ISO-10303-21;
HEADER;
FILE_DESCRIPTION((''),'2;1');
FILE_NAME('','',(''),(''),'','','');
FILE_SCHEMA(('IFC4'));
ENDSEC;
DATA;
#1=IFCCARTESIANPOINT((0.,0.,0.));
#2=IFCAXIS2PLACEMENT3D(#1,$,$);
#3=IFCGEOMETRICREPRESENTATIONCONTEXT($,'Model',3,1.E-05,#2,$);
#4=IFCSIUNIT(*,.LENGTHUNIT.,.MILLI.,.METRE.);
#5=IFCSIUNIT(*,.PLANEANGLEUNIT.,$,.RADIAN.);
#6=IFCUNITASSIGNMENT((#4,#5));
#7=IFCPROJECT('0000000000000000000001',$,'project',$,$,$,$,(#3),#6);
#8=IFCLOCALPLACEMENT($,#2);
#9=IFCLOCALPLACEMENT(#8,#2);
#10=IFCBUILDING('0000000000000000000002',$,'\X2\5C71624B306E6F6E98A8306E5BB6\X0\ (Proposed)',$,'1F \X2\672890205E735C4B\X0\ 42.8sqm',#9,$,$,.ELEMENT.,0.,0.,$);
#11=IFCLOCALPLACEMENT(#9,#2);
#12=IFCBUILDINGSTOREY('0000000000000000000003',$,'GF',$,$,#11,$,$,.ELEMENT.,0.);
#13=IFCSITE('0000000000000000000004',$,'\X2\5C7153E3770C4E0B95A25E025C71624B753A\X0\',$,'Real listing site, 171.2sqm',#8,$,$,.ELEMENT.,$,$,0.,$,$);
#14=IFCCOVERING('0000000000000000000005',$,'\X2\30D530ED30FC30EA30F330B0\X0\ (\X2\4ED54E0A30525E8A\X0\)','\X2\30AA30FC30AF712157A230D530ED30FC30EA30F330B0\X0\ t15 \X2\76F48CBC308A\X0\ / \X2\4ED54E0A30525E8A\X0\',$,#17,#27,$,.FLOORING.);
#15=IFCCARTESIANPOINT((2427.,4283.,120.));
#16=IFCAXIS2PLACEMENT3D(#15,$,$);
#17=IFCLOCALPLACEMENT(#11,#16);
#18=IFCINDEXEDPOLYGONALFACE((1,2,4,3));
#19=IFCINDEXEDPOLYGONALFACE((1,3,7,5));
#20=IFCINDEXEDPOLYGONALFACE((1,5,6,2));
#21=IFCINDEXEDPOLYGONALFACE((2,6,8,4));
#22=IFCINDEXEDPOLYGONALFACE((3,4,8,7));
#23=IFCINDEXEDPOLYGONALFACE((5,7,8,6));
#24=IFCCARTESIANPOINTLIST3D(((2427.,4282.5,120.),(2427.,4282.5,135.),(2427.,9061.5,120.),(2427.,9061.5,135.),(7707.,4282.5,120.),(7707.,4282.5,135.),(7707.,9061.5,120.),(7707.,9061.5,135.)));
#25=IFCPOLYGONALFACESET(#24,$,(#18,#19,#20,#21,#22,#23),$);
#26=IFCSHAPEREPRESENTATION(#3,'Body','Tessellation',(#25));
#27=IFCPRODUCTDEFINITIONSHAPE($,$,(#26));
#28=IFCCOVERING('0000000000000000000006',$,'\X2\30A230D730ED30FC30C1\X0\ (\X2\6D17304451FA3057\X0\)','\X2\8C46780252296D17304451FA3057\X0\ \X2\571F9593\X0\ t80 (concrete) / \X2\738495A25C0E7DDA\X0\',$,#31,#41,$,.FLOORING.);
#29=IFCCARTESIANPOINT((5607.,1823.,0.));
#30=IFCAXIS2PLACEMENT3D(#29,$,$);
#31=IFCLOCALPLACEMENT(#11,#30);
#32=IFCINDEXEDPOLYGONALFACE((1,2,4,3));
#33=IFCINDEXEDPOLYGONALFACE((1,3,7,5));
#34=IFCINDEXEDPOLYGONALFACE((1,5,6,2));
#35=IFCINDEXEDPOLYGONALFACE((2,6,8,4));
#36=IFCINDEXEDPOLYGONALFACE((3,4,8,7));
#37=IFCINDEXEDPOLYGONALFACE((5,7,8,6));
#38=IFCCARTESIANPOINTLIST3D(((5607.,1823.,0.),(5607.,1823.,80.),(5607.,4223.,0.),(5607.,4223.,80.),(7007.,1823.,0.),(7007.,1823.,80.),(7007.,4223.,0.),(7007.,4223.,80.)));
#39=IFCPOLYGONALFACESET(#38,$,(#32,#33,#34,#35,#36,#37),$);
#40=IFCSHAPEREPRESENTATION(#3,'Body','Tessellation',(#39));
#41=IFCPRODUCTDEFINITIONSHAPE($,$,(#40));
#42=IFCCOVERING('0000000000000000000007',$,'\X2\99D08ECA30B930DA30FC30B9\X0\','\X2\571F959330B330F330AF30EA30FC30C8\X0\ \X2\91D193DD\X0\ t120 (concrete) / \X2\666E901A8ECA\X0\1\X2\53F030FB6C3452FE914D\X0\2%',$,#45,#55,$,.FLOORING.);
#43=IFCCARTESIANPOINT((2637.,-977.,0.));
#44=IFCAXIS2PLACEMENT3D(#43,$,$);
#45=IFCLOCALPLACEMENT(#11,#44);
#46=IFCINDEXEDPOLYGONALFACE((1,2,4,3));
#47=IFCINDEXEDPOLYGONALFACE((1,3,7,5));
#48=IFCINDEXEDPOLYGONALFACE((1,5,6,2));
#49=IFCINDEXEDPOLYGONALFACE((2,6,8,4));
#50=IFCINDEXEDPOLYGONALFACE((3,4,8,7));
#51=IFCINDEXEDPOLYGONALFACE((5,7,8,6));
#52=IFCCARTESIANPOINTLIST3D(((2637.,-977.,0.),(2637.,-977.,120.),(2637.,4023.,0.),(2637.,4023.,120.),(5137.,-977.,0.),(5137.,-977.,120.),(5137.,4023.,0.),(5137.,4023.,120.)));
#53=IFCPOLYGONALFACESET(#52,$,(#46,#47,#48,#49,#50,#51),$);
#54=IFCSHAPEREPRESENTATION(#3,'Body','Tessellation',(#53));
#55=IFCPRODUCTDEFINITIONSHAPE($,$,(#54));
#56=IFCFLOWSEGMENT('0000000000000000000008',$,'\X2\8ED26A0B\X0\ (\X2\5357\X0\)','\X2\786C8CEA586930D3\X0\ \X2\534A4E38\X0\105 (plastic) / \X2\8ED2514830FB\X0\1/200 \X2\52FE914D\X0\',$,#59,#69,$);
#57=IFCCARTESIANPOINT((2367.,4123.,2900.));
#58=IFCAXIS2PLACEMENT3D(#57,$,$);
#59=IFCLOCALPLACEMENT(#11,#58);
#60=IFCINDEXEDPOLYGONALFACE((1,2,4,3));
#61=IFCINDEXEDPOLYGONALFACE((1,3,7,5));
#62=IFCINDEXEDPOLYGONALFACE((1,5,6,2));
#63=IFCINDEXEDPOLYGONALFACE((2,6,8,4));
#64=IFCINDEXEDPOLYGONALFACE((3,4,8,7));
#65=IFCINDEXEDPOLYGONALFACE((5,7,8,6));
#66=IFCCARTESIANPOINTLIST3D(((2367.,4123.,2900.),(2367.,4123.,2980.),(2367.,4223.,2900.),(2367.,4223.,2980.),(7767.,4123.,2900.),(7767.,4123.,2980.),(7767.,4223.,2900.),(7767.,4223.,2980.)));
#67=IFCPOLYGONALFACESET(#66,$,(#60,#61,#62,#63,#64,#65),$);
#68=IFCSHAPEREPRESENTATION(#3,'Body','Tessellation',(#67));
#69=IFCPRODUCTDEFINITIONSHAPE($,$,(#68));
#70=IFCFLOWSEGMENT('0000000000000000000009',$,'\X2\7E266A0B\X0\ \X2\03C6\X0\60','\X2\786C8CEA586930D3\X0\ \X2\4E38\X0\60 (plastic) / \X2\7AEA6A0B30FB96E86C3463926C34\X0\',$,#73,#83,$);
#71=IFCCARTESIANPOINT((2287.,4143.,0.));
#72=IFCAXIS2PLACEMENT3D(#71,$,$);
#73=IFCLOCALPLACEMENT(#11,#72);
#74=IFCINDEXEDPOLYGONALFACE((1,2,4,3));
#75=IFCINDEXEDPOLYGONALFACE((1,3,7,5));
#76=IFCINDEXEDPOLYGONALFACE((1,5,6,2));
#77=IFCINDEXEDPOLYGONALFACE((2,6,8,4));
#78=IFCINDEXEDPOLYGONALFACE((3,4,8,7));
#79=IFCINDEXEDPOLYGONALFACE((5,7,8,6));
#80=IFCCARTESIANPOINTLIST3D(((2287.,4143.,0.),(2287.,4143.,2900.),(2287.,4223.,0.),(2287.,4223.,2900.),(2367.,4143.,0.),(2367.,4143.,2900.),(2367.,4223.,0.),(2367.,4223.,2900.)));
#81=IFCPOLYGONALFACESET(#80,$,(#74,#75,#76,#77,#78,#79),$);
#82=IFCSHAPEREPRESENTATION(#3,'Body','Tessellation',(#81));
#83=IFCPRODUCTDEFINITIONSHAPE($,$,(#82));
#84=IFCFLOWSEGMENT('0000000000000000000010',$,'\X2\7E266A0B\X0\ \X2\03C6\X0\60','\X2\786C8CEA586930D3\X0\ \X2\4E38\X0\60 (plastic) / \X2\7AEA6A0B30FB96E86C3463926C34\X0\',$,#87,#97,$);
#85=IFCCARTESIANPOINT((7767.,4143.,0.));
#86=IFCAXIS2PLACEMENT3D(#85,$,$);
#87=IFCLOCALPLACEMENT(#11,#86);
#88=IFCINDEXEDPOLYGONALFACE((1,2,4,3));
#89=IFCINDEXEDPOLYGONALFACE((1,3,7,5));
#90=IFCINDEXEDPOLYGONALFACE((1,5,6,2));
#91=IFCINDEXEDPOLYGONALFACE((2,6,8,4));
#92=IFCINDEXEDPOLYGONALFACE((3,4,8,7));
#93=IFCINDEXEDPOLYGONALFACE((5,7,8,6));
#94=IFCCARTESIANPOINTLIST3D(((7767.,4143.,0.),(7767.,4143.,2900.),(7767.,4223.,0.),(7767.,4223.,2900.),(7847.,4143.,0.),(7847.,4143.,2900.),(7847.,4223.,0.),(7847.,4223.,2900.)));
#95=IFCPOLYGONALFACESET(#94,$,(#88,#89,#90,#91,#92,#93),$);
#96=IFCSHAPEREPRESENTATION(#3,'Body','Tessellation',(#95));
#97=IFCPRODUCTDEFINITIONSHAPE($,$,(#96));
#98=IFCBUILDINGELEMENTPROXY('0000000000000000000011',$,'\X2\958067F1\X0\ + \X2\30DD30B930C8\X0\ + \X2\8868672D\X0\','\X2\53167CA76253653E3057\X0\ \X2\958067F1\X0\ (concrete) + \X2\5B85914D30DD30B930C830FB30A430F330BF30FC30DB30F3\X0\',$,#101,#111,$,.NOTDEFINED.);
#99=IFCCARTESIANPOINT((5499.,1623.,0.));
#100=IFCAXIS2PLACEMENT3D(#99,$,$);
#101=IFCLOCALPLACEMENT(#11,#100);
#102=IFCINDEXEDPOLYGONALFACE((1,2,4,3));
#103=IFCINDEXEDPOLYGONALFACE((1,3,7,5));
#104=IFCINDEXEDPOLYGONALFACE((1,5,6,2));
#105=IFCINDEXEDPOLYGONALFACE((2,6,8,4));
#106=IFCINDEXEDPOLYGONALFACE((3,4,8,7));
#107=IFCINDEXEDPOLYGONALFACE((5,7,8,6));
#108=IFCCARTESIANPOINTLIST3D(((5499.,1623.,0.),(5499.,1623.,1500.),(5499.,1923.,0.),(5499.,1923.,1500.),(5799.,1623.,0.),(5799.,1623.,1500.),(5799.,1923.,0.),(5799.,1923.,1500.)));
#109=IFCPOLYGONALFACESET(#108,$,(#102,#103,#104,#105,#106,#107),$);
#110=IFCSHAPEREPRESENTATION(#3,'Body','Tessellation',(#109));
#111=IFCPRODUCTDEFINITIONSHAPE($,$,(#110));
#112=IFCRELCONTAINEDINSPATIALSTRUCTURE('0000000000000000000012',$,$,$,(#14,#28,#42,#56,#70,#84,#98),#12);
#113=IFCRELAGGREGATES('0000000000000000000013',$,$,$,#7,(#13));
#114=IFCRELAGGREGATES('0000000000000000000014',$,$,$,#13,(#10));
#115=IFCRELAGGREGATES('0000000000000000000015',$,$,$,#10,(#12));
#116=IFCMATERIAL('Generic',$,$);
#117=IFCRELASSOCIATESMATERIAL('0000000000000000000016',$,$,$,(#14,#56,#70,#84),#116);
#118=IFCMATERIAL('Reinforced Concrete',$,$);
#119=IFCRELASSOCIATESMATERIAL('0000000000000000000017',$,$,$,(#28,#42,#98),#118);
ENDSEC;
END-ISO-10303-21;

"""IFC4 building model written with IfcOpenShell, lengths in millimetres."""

from ifc_helpers import new_model, si_unit, frame, frame_2d, origin, place, context, project, spatial, rectangle, extrude, material, element, save


model = new_model("IFC4")

# Units and contexts
model_context = context("Model", 3, precision=1e-05, world=origin())
ifc_project = project(units=[si_unit("LENGTHUNIT", "METRE", prefix="MILLI"), si_unit("PLANEANGLEUNIT", "RADIAN")], contexts=[model_context])

# Site, building, storey
site_placement = place(None, origin())
site = spatial("IfcSite", under=ifc_project, at=site_placement, Name="山口県下関市山手町", ObjectType="Real listing site, 171.2sqm", CompositionType="ELEMENT", RefElevation=0.0)
building_placement = place(site_placement, origin())
building = spatial("IfcBuilding", under=site, at=building_placement, Name="山手の潮風の家 (Proposed)", ObjectType="1F 木造平屋 42.8sqm", CompositionType="ELEMENT", ElevationOfRefHeight=0.0, ElevationOfTerrain=0.0)
storey_placement = place(building_placement, origin())
storey = spatial("IfcBuildingStorey", under=building, at=storey_placement, Name="GF", CompositionType="ELEMENT", Elevation=0.0)

# Shared definitions
ifc_material_1 = material(Name="Reinforced Concrete")

# Coverings
ifc_material_2 = material(Name="Generic")
covering_1_placement = place(storey_placement, frame((2427.0, 4283.0, 120.0)))
element("IfcCovering", 1, at=covering_1_placement, inside=storey, material=ifc_material_2, Name="フローリング (仕上げ床)", Description="オーク無垢フローリング t15 直貼り / 仕上げ床", PredefinedType="FLOORING", context=model_context, shape_type="SweptSolid", body=[
    extrude(rectangle(XDim=5280.0, YDim=4779.0, at=frame_2d((2640.0, 2389.0))), frame((2427.0, 4283.0, 120.0)), (0.0, 0.0, 1.0), 15.0),
])
covering_2_placement = place(storey_placement, frame((5607.0, 1823.0, 0.0)))
element("IfcCovering", 2, at=covering_2_placement, inside=storey, material=ifc_material_1, Name="アプローチ (洗い出し)", Description="豆砂利洗い出し 土間 t80 (concrete) / 玄関導線", PredefinedType="FLOORING", context=model_context, shape_type="SweptSolid", body=[
    extrude(rectangle(XDim=1400.0, YDim=2400.0, at=frame_2d((700.0, 1200.0))), frame((5607.0, 1823.0, 0.0)), (0.0, 0.0, 1.0), 80.0),
])
covering_3_placement = place(storey_placement, frame((2637.0, -977.0, 0.0)))
element("IfcCovering", 3, at=covering_3_placement, inside=storey, material=ifc_material_1, Name="駐車スペース", Description="土間コンクリート 金鏝 t120 (concrete) / 普通車1台・水勾配2%", PredefinedType="FLOORING", context=model_context, shape_type="SweptSolid", body=[
    extrude(rectangle(XDim=2500.0, YDim=5000.0, at=frame_2d((1250.0, 2500.0))), frame((2637.0, -977.0, 0.0)), (0.0, 0.0, 1.0), 120.0),
])

# Flow segments
flow_segment_1_placement = place(storey_placement, frame((2367.0, 4123.0, 2900.0)))
element("IfcFlowSegment", 4, at=flow_segment_1_placement, inside=storey, material=ifc_material_2, Name="軒樋 (南)", Description="硬質塩ビ 半丸105 (plastic) / 軒先・1/200 勾配", context=model_context, shape_type="SweptSolid", body=[
    extrude(rectangle(XDim=5400.0, YDim=100.0, at=frame_2d((2700.0, 50.0))), frame((2367.0, 4123.0, 2900.0)), (0.0, 0.0, 1.0), 80.0),
])
flow_segment_2_placement = place(storey_placement, frame((2287.0, 4143.0, 0.0)))
element("IfcFlowSegment", 5, at=flow_segment_2_placement, inside=storey, material=ifc_material_2, Name="縦樋 φ60", Description="硬質塩ビ 丸60 (plastic) / 竪樋・雨水排水", context=model_context, shape_type="SweptSolid", body=[
    extrude(rectangle(XDim=80.0, YDim=80.0, at=frame_2d((40.0, 40.0))), frame((2287.0, 4143.0, 0.0)), (0.0, 0.0, 1.0), 2900.0),
])
flow_segment_3_placement = place(storey_placement, frame((7767.0, 4143.0, 0.0)))
element("IfcFlowSegment", 6, at=flow_segment_3_placement, inside=storey, material=ifc_material_2, Name="縦樋 φ60", Description="硬質塩ビ 丸60 (plastic) / 竪樋・雨水排水", context=model_context, shape_type="SweptSolid", body=[
    extrude(rectangle(XDim=80.0, YDim=80.0, at=frame_2d((40.0, 40.0))), frame((7767.0, 4143.0, 0.0)), (0.0, 0.0, 1.0), 2900.0),
])

# Building element proxy
proxy_placement = place(storey_placement, frame((5499.0, 1623.0, 0.0)))
element("IfcBuildingElementProxy", 7, at=proxy_placement, inside=storey, material=ifc_material_1, Name="門柱 + ポスト + 表札", Description="化粧打放し 門柱 (concrete) + 宅配ポスト・インターホン", PredefinedType="NOTDEFINED", context=model_context, shape_type="SweptSolid", body=[
    extrude(rectangle(XDim=300.0, YDim=300.0, at=frame_2d((150.0, 150.0))), frame((5499.0, 1623.0, 0.0)), (0.0, 0.0, 1.0), 1500.0),
])

save(model, "model.ifc")
